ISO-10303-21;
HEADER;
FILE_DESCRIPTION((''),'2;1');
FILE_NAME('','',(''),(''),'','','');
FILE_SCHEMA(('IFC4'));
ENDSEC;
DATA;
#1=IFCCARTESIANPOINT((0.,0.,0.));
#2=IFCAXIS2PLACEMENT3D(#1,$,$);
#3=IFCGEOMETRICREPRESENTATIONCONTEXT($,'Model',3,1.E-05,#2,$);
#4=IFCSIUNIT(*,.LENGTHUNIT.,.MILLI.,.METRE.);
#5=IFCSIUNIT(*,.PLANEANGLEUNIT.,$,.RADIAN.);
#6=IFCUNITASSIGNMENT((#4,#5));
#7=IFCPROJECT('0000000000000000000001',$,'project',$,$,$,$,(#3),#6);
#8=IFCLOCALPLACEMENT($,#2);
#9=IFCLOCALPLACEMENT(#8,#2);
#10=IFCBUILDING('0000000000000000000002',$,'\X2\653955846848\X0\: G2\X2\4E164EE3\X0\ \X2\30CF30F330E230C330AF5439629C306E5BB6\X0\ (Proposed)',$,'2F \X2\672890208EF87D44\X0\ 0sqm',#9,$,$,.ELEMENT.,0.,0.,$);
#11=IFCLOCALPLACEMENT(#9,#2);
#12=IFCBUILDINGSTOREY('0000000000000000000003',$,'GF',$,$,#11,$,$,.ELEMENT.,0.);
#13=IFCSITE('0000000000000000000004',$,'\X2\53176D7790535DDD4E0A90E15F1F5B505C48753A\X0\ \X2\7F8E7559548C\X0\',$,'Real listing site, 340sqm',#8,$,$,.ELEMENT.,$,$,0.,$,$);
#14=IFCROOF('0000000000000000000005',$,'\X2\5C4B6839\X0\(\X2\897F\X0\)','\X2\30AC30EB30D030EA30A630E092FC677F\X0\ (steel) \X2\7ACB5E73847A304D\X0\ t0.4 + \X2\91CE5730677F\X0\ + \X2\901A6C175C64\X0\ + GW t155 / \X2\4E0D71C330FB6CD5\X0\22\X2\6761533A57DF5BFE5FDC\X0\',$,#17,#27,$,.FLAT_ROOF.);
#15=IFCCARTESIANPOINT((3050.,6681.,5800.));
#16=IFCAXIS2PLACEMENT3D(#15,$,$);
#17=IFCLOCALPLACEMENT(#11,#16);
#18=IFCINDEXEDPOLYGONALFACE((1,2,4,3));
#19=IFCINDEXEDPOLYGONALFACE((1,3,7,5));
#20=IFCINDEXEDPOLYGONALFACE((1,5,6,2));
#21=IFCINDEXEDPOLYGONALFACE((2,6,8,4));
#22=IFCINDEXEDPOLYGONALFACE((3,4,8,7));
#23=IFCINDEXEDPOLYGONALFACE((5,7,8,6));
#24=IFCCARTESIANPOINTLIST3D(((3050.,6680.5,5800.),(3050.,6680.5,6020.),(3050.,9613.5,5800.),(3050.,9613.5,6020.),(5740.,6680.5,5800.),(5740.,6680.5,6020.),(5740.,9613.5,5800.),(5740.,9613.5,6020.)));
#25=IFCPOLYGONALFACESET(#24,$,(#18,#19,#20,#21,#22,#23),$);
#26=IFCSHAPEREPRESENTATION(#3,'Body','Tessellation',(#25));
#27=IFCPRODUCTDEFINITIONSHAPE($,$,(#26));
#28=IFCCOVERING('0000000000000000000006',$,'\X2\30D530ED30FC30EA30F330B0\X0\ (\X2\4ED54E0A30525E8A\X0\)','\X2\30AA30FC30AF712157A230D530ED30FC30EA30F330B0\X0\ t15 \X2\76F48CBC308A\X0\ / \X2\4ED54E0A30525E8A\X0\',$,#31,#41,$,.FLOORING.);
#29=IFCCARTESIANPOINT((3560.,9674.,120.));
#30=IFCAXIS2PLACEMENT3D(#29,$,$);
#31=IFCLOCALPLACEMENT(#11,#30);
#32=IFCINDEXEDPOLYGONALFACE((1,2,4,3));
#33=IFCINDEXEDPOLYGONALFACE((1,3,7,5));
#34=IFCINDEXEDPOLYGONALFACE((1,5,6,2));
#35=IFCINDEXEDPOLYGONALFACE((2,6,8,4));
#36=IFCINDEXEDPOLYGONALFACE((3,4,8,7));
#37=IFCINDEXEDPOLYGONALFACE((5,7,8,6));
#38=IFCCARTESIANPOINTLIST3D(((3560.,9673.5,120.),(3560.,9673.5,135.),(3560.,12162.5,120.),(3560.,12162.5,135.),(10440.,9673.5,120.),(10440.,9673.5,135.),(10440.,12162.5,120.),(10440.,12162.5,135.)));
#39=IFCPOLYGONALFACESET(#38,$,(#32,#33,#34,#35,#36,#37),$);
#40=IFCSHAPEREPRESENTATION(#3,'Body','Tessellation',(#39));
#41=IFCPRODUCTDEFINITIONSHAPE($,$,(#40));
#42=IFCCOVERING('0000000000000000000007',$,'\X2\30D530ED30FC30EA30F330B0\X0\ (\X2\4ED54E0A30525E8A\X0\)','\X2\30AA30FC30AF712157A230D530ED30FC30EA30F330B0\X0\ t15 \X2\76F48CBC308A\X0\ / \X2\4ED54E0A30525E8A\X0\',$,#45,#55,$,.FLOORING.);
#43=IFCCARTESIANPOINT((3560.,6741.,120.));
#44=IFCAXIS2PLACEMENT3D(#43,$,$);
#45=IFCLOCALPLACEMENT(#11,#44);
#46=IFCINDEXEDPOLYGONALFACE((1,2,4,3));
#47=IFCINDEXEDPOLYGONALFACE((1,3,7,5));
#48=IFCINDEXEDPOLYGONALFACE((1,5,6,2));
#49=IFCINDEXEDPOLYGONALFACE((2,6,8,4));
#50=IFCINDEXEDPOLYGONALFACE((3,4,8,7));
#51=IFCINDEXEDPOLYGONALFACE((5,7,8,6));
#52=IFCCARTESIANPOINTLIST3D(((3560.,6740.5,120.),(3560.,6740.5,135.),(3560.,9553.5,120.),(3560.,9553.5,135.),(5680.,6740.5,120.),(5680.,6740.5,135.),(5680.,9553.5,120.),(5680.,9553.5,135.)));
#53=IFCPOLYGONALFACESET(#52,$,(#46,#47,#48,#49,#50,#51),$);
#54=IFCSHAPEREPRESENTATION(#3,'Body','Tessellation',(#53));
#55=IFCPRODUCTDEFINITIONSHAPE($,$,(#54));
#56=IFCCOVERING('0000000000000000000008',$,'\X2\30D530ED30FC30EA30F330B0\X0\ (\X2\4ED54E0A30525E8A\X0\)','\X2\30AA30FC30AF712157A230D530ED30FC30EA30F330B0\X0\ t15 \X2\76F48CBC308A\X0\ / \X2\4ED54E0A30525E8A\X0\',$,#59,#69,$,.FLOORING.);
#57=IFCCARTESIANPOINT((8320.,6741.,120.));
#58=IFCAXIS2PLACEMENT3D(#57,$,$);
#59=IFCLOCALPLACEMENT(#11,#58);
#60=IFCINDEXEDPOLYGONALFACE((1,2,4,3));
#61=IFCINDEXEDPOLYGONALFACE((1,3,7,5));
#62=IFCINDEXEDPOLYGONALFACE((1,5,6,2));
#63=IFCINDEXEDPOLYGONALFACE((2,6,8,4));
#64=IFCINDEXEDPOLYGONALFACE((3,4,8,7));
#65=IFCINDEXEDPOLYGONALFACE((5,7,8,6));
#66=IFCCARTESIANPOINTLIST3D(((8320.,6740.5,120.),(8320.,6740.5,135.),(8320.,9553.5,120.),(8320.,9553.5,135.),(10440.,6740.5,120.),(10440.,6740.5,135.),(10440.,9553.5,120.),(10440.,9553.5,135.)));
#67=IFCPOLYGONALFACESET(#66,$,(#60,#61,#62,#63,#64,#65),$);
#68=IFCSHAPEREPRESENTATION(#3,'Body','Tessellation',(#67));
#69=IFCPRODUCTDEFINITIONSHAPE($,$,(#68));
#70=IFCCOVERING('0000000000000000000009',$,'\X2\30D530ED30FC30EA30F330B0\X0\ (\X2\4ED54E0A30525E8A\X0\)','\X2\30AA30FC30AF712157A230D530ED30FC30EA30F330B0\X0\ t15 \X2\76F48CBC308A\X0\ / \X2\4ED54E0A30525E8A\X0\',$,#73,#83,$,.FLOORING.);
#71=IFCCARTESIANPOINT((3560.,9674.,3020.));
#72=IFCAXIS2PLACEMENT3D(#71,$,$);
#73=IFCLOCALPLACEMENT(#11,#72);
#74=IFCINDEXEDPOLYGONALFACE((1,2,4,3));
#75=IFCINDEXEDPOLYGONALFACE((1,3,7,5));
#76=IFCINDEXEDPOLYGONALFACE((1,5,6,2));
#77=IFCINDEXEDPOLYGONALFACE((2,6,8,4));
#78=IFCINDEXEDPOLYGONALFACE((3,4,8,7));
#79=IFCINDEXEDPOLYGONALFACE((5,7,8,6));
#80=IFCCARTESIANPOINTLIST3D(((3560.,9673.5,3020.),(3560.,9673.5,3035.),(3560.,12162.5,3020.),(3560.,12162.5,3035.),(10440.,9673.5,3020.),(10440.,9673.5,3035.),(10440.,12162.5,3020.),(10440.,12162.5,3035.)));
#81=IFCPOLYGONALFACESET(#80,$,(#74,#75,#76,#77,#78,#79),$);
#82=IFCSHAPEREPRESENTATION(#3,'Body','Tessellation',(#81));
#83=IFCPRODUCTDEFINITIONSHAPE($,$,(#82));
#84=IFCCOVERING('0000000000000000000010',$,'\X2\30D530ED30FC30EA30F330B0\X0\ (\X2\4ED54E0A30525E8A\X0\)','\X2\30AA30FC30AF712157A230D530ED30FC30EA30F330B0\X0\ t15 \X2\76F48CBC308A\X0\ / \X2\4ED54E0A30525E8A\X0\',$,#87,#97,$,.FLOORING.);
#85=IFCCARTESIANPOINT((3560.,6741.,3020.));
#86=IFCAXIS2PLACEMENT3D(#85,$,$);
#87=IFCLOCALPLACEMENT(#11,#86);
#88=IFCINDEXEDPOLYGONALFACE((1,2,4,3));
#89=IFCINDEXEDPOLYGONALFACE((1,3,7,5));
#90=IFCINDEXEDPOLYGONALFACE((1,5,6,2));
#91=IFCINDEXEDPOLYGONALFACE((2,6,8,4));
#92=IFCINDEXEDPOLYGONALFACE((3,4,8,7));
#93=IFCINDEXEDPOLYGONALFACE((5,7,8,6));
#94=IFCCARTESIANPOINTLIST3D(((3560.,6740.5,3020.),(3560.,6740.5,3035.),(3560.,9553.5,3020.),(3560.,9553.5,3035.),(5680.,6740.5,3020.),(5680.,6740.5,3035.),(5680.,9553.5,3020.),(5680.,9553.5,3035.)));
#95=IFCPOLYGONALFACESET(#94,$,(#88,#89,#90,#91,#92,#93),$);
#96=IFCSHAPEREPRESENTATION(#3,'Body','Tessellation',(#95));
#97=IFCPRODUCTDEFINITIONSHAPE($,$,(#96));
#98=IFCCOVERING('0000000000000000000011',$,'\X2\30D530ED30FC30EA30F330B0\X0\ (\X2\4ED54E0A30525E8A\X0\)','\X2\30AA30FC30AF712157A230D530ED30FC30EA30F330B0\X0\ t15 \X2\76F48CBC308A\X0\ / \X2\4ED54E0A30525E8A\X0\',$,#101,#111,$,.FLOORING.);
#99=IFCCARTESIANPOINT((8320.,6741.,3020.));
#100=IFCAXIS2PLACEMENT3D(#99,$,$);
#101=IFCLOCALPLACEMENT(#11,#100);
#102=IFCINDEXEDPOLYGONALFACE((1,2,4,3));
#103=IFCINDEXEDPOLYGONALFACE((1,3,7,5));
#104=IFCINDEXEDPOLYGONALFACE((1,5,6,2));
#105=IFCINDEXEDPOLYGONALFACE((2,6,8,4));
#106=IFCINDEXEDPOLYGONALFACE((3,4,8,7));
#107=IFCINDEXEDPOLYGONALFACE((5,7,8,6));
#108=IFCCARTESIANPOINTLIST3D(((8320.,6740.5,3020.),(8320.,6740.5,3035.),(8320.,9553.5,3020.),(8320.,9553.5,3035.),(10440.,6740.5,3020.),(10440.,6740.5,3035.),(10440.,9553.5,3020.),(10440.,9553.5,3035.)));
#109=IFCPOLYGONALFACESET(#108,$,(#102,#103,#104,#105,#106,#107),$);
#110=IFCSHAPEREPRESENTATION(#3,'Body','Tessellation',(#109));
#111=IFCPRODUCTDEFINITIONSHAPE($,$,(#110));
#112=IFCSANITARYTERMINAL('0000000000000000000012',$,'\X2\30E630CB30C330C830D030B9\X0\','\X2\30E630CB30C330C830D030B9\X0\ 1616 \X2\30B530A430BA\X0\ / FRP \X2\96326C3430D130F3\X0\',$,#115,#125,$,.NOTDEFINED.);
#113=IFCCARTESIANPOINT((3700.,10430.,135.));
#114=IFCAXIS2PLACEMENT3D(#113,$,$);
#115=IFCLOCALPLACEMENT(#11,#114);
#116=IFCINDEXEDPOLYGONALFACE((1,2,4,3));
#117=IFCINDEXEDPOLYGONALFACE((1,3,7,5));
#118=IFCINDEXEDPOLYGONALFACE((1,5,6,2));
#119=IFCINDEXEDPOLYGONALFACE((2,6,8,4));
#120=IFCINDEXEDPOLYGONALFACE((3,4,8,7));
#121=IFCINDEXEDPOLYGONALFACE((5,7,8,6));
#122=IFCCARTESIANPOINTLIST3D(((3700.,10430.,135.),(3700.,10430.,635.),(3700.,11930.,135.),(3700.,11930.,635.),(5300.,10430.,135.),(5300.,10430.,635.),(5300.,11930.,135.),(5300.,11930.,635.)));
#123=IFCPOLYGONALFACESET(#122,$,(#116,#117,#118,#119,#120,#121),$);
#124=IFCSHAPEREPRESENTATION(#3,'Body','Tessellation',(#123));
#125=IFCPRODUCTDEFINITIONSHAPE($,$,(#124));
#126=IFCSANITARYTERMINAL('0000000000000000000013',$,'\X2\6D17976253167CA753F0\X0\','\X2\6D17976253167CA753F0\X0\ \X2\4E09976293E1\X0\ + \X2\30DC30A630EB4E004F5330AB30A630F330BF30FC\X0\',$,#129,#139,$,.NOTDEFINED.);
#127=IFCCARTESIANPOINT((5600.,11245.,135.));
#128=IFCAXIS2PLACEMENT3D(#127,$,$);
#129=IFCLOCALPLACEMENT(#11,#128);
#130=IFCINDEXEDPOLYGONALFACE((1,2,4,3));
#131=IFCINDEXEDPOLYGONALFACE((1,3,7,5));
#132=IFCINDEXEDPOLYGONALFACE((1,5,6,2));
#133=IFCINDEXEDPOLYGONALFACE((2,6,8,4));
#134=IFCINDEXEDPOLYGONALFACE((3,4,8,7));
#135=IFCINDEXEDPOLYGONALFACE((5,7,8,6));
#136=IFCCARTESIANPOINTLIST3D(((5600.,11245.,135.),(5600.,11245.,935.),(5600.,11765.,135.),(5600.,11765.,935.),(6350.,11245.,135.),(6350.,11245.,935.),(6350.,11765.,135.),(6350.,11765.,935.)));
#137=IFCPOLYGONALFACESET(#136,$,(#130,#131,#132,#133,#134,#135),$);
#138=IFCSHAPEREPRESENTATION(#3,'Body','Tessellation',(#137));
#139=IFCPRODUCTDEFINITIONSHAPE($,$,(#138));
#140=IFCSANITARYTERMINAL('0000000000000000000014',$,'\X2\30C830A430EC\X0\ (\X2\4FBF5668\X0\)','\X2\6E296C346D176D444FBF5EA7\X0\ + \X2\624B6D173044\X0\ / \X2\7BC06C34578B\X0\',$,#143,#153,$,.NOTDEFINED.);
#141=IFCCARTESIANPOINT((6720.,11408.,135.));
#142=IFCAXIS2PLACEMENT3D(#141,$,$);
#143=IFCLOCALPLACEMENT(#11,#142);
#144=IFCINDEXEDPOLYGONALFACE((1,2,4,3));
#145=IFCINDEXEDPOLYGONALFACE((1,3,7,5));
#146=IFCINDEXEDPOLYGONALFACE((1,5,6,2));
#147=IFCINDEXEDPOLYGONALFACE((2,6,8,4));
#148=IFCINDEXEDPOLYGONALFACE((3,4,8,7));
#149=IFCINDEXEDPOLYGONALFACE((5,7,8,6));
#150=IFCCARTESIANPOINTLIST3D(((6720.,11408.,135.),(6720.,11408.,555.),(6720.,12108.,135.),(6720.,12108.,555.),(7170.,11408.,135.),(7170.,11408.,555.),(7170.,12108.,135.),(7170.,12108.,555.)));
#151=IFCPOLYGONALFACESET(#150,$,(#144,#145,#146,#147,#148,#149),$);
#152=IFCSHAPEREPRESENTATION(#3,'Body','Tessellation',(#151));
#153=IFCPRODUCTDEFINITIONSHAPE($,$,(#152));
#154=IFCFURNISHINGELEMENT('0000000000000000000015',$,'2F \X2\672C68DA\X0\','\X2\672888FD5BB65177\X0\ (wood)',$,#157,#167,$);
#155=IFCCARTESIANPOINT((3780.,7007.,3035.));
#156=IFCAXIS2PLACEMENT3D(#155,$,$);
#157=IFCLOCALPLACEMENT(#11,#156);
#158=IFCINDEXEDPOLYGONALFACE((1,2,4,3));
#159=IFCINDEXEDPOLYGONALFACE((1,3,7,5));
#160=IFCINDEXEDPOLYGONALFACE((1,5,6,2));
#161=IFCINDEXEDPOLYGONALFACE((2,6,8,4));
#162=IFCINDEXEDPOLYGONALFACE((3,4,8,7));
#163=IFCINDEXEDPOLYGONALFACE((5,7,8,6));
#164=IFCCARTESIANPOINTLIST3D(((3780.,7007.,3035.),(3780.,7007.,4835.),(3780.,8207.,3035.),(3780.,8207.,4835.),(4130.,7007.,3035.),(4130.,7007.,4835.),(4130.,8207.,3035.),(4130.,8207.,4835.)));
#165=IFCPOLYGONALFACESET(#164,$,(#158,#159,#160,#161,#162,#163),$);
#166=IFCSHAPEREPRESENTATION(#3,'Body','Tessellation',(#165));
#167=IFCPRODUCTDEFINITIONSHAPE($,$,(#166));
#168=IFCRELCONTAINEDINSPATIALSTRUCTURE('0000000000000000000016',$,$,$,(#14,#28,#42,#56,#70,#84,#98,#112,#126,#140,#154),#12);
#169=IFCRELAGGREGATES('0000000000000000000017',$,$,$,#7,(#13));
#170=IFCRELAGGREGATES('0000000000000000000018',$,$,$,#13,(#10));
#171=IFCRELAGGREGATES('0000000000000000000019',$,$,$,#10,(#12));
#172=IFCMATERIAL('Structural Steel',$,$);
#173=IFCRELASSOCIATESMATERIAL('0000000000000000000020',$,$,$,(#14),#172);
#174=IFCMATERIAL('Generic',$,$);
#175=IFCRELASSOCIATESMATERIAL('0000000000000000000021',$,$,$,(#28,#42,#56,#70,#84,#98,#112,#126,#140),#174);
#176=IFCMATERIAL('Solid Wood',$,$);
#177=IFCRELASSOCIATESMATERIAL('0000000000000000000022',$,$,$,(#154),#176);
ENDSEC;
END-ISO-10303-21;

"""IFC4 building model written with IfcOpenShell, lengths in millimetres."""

from ifc_helpers import new_model, si_unit, frame, frame_2d, origin, place, context, project, spatial, rectangle, extrude, material, element, save


model = new_model("IFC4")

# Units and contexts
model_context = context("Model", 3, precision=1e-05, world=origin())
ifc_project = project(units=[si_unit("LENGTHUNIT", "METRE", prefix="MILLI"), si_unit("PLANEANGLEUNIT", "RADIAN")], contexts=[model_context])

# Site, building, storey
site_placement = place(None, origin())
site = spatial("IfcSite", under=ifc_project, at=site_placement, Name="北海道川上郡弟子屈町 美留和", ObjectType="Real listing site, 340sqm", CompositionType="ELEMENT", RefElevation=0.0)
building_placement = place(site_placement, origin())
building = spatial("IfcBuilding", under=site, at=building_placement, Name="改善案: G2世代 ハンモック吹抜の家 (Proposed)", ObjectType="2F 木造軸組 0sqm", CompositionType="ELEMENT", ElevationOfRefHeight=0.0, ElevationOfTerrain=0.0)
storey_placement = place(building_placement, origin())
storey = spatial("IfcBuildingStorey", under=building, at=storey_placement, Name="GF", CompositionType="ELEMENT", Elevation=0.0)

# Shared definitions
ifc_material_1 = material(Name="Solid Wood")

# Shared definitions
ifc_material_2 = material(Name="Generic")

# Roof
ifc_material_3 = material(Name="Structural Steel")
roof_1_placement = place(storey_placement, frame((3050.0, 6681.0, 5800.0)))
element("IfcRoof", 1, at=roof_1_placement, inside=storey, material=ifc_material_3, Name="屋根(西)", Description="ガルバリウム鋼板 (steel) 立平葺き t0.4 + 野地板 + 通気層 + GW t155 / 不燃・法22条区域対応", PredefinedType="FLAT_ROOF", context=model_context, shape_type="SweptSolid", body=[
    extrude(rectangle(XDim=2690.0, YDim=2933.0, at=frame_2d((1345.0, 1466.0))), frame((3050.0, 6681.0, 5800.0)), (0.0, 0.0, 1.0), 220.0),
])

# Coverings
covering_1_placement = place(storey_placement, frame((3560.0, 9674.0, 120.0)))
element("IfcCovering", 2, at=covering_1_placement, inside=storey, material=ifc_material_2, Name="フローリング (仕上げ床)", Description="オーク無垢フローリング t15 直貼り / 仕上げ床", PredefinedType="FLOORING", context=model_context, shape_type="SweptSolid", body=[
    extrude(rectangle(XDim=6880.0, YDim=2489.0, at=frame_2d((3440.0, 1244.0))), frame((3560.0, 9674.0, 120.0)), (0.0, 0.0, 1.0), 15.0),
])
covering_2_placement = place(storey_placement, frame((3560.0, 6741.0, 120.0)))
element("IfcCovering", 3, at=covering_2_placement, inside=storey, material=ifc_material_2, Name="フローリング (仕上げ床)", Description="オーク無垢フローリング t15 直貼り / 仕上げ床", PredefinedType="FLOORING", context=model_context, shape_type="SweptSolid", body=[
    extrude(rectangle(XDim=2120.0, YDim=2813.0, at=frame_2d((1060.0, 1406.0))), frame((3560.0, 6741.0, 120.0)), (0.0, 0.0, 1.0), 15.0),
])
covering_3_placement = place(storey_placement, frame((8320.0, 6741.0, 120.0)))
element("IfcCovering", 4, at=covering_3_placement, inside=storey, material=ifc_material_2, Name="フローリング (仕上げ床)", Description="オーク無垢フローリング t15 直貼り / 仕上げ床", PredefinedType="FLOORING", context=model_context, shape_type="SweptSolid", body=[
    extrude(rectangle(XDim=2120.0, YDim=2813.0, at=frame_2d((1060.0, 1406.0))), frame((8320.0, 6741.0, 120.0)), (0.0, 0.0, 1.0), 15.0),
])
covering_4_placement = place(storey_placement, frame((3560.0, 9674.0, 3020.0)))
element("IfcCovering", 5, at=covering_4_placement, inside=storey, material=ifc_material_2, Name="フローリング (仕上げ床)", Description="オーク無垢フローリング t15 直貼り / 仕上げ床", PredefinedType="FLOORING", context=model_context, shape_type="SweptSolid", body=[
    extrude(rectangle(XDim=6880.0, YDim=2489.0, at=frame_2d((3440.0, 1244.0))), frame((3560.0, 9674.0, 3020.0)), (0.0, 0.0, 1.0), 15.0),
])
covering_5_placement = place(storey_placement, frame((3560.0, 6741.0, 3020.0)))
element("IfcCovering", 6, at=covering_5_placement, inside=storey, material=ifc_material_2, Name="フローリング (仕上げ床)", Description="オーク無垢フローリング t15 直貼り / 仕上げ床", PredefinedType="FLOORING", context=model_context, shape_type="SweptSolid", body=[
    extrude(rectangle(XDim=2120.0, YDim=2813.0, at=frame_2d((1060.0, 1406.0))), frame((3560.0, 6741.0, 3020.0)), (0.0, 0.0, 1.0), 15.0),
])
covering_6_placement = place(storey_placement, frame((8320.0, 6741.0, 3020.0)))
element("IfcCovering", 7, at=covering_6_placement, inside=storey, material=ifc_material_2, Name="フローリング (仕上げ床)", Description="オーク無垢フローリング t15 直貼り / 仕上げ床", PredefinedType="FLOORING", context=model_context, shape_type="SweptSolid", body=[
    extrude(rectangle(XDim=2120.0, YDim=2813.0, at=frame_2d((1060.0, 1406.0))), frame((8320.0, 6741.0, 3020.0)), (0.0, 0.0, 1.0), 15.0),
])

# Sanitary terminals
sanitary_terminal_1_placement = place(storey_placement, frame((3700.0, 10430.0, 135.0)))
element("IfcSanitaryTerminal", 8, at=sanitary_terminal_1_placement, inside=storey, material=ifc_material_2, Name="ユニットバス", Description="ユニットバス 1616 サイズ / FRP 防水パン", PredefinedType="NOTDEFINED", context=model_context, shape_type="SweptSolid", body=[
    extrude(rectangle(XDim=1600.0, YDim=1500.0, at=frame_2d((800.0, 750.0))), frame((3700.0, 10430.0, 135.0)), (0.0, 0.0, 1.0), 500.0),
])
sanitary_terminal_2_placement = place(storey_placement, frame((5600.0, 11245.0, 135.0)))
element("IfcSanitaryTerminal", 9, at=sanitary_terminal_2_placement, inside=storey, material=ifc_material_2, Name="洗面化粧台", Description="洗面化粧台 三面鏡 + ボウル一体カウンター", PredefinedType="NOTDEFINED", context=model_context, shape_type="SweptSolid", body=[
    extrude(rectangle(XDim=750.0, YDim=520.0, at=frame_2d((375.0, 260.0))), frame((5600.0, 11245.0, 135.0)), (0.0, 0.0, 1.0), 800.0),
])
sanitary_terminal_3_placement = place(storey_placement, frame((6720.0, 11408.0, 135.0)))
element("IfcSanitaryTerminal", 10, at=sanitary_terminal_3_placement, inside=storey, material=ifc_material_2, Name="トイレ (便器)", Description="温水洗浄便座 + 手洗い / 節水型", PredefinedType="NOTDEFINED", context=model_context, shape_type="SweptSolid", body=[
    extrude(rectangle(XDim=450.0, YDim=700.0, at=frame_2d((225.0, 350.0))), frame((6720.0, 11408.0, 135.0)), (0.0, 0.0, 1.0), 420.0),
])

# Furnishing element
furnishing_placement = place(storey_placement, frame((3780.0, 7007.0, 3035.0)))
element("IfcFurnishingElement", 11, at=furnishing_placement, inside=storey, material=ifc_material_1, Name="2F 本棚", Description="木製家具 (wood)", context=model_context, shape_type="SweptSolid", body=[
    extrude(rectangle(XDim=350.0, YDim=1200.0, at=frame_2d((175.0, 600.0))), frame((3780.0, 7007.0, 3035.0)), (0.0, 0.0, 1.0), 1800.0),
])

save(model, "model.ifc")
